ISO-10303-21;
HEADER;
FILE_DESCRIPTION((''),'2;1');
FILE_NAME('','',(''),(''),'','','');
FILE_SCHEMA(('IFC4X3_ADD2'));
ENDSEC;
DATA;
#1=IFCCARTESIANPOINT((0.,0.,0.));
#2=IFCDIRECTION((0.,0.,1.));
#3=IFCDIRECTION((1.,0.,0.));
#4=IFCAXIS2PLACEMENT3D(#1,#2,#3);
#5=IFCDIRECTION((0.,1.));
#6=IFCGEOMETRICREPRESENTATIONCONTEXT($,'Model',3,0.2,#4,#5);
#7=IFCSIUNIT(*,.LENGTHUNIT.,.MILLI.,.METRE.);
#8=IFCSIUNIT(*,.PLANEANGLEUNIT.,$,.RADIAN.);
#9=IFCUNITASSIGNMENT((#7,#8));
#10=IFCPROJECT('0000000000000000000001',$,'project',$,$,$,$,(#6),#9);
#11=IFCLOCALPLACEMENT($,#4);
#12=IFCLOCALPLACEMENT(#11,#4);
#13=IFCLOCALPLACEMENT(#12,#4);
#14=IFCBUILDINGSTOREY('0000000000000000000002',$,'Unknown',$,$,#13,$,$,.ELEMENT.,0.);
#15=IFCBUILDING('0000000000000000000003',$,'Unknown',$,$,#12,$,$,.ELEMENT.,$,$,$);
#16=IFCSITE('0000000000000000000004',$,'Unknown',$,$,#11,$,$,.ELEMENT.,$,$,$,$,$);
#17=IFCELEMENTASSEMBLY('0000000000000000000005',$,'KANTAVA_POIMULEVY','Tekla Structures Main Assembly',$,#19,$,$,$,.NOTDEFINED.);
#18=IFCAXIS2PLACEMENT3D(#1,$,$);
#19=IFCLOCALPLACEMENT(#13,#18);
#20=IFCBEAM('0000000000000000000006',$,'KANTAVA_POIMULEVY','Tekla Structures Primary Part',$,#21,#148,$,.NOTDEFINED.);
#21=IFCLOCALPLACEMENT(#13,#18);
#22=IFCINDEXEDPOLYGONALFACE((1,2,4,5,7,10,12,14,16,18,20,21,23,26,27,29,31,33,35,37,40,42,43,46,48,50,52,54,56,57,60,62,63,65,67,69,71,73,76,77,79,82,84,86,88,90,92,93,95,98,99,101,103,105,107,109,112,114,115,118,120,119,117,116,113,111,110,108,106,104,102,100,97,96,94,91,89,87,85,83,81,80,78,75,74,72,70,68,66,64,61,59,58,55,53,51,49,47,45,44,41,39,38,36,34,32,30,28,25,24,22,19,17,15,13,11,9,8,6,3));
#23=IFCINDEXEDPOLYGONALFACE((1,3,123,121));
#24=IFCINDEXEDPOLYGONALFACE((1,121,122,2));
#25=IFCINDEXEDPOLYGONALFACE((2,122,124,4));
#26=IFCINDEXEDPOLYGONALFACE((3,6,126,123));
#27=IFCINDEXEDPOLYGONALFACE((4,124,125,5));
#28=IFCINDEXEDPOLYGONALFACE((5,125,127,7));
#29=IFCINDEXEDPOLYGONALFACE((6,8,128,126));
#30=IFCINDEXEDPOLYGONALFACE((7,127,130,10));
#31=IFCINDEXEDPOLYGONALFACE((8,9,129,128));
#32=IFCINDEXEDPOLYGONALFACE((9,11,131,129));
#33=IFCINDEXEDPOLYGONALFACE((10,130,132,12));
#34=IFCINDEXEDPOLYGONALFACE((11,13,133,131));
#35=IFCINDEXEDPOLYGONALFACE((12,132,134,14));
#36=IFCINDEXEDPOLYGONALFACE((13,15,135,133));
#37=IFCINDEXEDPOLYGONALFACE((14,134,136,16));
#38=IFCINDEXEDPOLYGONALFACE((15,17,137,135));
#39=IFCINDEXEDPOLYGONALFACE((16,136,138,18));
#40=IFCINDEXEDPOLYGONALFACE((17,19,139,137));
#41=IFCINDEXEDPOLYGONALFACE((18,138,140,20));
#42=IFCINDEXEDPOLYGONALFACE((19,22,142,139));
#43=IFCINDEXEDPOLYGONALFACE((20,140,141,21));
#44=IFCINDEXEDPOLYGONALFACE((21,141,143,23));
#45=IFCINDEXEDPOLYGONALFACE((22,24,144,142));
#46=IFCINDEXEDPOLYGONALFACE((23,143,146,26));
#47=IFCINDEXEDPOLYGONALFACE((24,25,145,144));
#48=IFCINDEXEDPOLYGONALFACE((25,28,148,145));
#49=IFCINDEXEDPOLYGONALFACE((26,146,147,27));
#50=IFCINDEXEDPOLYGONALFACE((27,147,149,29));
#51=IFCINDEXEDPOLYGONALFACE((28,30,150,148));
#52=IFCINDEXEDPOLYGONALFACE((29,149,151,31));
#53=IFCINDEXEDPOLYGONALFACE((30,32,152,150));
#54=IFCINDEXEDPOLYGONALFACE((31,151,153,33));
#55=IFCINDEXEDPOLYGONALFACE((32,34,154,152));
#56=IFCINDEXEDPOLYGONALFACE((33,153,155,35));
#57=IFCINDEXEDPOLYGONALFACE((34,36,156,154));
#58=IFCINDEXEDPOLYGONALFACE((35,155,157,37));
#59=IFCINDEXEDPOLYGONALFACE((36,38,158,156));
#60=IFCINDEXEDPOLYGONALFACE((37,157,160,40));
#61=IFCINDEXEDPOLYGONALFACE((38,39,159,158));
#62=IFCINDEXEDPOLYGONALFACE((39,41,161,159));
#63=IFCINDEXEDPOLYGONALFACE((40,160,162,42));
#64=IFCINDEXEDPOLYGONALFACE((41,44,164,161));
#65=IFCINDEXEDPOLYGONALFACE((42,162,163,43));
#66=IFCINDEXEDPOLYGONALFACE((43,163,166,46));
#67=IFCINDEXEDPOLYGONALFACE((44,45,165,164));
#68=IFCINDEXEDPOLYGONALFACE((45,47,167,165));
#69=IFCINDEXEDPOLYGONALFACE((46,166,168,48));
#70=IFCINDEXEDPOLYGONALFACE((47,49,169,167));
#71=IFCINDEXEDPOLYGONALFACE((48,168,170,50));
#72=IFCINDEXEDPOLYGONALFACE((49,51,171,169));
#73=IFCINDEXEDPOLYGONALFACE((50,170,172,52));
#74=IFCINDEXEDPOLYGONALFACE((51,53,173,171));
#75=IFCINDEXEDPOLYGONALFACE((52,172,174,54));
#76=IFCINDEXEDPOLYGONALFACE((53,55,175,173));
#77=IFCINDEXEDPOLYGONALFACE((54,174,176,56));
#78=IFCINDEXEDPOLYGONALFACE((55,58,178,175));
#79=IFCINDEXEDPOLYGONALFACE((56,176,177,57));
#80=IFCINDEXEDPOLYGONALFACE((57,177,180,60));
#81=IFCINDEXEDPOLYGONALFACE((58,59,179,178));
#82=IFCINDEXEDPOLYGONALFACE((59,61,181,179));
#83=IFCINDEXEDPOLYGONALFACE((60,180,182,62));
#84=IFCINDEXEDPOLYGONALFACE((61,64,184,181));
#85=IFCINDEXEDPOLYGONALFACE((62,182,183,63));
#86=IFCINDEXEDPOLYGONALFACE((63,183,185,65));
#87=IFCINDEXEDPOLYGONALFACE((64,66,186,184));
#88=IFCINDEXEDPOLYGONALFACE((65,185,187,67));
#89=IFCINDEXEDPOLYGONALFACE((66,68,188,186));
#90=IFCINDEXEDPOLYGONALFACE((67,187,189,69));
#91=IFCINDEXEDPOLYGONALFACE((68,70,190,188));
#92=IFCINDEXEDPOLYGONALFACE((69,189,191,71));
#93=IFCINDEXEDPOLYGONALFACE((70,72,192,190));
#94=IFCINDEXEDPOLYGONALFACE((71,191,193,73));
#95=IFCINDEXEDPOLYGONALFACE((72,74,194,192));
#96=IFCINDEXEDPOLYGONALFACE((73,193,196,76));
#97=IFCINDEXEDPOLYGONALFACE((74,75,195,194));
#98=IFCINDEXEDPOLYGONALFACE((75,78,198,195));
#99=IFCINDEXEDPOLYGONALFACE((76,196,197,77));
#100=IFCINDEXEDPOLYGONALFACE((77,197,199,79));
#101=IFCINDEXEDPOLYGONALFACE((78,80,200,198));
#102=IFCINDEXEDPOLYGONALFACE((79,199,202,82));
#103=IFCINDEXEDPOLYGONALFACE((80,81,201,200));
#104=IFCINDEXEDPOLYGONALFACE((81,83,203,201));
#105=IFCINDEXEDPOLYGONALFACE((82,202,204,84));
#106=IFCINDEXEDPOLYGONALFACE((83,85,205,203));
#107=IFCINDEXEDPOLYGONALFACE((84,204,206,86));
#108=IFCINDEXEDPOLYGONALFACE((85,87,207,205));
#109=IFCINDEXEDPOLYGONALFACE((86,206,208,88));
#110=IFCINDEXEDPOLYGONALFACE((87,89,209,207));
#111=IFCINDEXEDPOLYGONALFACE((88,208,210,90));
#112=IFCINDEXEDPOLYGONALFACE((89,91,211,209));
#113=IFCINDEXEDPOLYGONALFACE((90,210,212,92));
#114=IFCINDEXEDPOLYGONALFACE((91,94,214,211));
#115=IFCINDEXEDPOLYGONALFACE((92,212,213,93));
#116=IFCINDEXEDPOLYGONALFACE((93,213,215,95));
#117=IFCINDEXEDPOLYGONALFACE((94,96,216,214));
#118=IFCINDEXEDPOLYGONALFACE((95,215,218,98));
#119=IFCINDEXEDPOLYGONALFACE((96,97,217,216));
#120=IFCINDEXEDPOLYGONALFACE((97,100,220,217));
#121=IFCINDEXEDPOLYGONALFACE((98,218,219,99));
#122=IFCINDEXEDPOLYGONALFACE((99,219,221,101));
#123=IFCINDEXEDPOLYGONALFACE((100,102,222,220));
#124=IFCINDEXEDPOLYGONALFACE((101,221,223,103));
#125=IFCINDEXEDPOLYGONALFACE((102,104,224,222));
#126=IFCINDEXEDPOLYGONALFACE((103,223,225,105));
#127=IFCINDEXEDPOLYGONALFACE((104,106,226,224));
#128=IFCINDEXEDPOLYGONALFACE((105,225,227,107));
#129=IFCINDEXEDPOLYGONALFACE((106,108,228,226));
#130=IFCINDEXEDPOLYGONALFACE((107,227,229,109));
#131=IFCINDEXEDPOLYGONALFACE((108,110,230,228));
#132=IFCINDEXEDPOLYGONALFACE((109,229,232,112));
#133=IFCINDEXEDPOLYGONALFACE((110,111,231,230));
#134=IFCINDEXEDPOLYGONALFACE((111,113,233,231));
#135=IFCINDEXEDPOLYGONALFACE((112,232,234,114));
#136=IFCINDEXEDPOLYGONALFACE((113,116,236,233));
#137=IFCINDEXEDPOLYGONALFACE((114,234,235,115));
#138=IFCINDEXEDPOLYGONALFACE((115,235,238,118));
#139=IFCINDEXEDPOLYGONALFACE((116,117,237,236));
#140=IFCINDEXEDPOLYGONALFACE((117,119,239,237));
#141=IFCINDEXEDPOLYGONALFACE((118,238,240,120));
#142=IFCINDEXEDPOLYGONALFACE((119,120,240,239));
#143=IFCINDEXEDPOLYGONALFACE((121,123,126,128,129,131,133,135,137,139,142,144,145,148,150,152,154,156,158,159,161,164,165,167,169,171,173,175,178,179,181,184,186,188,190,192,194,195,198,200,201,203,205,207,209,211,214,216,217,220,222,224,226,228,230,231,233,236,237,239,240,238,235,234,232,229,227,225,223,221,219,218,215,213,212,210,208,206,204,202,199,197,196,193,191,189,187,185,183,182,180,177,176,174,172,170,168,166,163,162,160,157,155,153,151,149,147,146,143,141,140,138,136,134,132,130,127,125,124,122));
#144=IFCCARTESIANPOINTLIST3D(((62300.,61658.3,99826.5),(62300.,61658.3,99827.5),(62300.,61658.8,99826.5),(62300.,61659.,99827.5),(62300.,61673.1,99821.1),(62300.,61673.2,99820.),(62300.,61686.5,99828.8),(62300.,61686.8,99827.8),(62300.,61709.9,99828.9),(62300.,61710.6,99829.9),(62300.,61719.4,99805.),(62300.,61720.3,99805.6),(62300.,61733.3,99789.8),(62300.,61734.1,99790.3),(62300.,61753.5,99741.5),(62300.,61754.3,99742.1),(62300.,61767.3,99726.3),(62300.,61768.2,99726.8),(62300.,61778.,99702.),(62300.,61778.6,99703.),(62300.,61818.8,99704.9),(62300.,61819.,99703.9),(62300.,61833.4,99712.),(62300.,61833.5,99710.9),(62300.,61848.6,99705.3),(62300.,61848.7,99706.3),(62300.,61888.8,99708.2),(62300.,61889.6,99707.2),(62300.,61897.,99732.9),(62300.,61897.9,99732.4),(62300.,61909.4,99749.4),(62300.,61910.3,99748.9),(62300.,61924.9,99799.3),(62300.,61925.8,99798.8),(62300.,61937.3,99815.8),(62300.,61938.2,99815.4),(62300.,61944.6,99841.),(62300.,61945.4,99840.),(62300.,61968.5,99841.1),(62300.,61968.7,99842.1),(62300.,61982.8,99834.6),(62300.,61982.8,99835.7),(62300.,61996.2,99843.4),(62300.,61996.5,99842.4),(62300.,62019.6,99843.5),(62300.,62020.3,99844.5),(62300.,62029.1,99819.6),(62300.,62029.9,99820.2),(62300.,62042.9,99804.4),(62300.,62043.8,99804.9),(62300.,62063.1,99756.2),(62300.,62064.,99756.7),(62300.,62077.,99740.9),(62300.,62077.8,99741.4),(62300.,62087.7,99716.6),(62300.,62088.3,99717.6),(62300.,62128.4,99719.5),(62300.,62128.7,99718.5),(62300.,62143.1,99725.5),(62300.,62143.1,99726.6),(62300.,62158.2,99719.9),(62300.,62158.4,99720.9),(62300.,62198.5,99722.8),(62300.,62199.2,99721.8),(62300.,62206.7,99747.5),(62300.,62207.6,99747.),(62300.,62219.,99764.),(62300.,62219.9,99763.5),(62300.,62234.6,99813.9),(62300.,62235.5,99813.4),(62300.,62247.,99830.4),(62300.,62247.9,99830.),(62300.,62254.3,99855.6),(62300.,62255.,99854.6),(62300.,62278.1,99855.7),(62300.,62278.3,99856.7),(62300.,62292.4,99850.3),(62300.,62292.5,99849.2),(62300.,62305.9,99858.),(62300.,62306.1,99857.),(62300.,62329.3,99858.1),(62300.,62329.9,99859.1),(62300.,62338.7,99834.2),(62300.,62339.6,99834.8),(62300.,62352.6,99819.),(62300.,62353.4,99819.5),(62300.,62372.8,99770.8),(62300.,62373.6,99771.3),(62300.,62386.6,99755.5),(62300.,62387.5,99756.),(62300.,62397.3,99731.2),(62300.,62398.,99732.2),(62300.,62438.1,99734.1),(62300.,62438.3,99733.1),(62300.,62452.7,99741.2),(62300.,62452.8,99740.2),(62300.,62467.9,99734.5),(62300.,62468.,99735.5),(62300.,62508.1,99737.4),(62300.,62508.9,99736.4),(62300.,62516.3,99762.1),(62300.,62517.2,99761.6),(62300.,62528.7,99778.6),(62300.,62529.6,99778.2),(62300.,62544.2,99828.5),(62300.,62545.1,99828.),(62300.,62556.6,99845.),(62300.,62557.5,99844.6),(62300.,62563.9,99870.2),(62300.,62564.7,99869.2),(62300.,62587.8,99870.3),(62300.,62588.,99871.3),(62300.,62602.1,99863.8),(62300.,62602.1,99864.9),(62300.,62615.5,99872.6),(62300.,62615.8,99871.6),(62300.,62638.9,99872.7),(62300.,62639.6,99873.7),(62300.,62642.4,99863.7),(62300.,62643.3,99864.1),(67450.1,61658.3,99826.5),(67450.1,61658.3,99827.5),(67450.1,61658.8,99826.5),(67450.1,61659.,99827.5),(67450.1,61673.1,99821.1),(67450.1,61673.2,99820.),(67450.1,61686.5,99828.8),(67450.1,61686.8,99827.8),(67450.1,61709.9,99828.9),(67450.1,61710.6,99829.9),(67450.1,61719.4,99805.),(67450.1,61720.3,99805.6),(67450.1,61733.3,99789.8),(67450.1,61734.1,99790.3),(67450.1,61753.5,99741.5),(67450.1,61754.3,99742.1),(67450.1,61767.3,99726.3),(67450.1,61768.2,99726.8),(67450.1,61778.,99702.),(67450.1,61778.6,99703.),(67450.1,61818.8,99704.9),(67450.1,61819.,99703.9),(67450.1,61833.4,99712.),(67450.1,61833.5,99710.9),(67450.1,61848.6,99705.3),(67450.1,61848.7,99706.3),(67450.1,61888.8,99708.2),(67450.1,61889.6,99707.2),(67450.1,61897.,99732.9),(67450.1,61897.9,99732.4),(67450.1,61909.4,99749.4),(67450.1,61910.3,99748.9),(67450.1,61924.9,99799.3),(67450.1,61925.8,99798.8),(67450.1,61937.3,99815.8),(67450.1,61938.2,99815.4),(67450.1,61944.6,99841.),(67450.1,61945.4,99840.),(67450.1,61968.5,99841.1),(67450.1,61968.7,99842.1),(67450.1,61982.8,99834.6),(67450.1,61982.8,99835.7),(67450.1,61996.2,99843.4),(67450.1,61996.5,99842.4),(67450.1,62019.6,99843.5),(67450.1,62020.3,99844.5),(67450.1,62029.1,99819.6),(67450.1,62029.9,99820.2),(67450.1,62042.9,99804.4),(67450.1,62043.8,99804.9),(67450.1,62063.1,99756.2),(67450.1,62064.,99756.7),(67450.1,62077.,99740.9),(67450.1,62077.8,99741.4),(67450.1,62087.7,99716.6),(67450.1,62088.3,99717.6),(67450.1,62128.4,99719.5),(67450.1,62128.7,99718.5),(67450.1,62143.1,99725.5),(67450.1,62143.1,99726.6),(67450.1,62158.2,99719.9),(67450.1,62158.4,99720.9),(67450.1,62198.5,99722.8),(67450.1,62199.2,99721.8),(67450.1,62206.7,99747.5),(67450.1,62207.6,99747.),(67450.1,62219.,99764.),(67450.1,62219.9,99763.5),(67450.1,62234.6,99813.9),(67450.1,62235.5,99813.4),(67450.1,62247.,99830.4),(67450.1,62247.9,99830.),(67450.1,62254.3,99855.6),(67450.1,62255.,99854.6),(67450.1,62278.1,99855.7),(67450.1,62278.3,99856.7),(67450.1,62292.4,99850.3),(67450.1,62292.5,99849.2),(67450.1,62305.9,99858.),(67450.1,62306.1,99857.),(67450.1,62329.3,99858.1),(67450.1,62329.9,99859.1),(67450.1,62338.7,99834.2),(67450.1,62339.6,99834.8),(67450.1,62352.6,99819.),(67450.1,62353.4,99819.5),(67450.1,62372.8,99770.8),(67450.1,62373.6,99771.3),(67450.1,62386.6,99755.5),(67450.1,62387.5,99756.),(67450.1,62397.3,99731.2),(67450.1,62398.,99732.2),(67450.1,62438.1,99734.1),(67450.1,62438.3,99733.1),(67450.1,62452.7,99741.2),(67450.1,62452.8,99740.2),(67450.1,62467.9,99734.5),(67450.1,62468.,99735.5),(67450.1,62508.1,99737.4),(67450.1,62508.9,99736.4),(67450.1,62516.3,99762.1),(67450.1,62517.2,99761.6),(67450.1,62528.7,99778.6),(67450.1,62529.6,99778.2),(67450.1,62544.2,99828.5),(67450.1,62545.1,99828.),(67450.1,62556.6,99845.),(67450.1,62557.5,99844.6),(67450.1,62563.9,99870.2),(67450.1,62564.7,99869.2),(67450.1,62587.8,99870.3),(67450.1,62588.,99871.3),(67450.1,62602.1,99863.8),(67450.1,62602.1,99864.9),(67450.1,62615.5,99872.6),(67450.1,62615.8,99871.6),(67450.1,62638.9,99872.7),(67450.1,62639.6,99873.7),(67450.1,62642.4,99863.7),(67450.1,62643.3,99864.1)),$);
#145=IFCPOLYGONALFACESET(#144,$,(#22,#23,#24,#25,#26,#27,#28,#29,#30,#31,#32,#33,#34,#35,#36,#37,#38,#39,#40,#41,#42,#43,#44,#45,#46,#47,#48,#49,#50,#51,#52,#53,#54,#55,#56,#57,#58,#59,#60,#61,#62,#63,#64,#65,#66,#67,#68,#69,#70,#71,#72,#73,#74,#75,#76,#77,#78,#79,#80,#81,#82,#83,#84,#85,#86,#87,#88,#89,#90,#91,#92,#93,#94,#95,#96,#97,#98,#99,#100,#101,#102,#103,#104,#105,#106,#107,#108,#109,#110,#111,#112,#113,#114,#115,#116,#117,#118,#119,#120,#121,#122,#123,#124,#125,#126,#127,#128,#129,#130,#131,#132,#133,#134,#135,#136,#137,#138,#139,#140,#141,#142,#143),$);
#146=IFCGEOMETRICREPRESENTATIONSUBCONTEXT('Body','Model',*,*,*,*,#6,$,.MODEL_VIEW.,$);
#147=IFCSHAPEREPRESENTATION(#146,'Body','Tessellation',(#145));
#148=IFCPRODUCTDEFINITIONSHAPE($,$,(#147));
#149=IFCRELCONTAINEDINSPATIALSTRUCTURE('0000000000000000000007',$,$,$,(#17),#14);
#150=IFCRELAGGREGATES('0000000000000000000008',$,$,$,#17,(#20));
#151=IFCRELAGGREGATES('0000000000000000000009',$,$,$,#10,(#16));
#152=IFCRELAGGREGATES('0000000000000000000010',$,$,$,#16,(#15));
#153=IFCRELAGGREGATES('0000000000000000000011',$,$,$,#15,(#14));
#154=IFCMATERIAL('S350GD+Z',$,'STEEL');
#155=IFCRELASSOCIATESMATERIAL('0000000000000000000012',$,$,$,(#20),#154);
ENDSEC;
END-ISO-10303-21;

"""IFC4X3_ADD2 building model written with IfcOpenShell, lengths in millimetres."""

from ifc_helpers import new_model, si_unit, direction, frame, origin_with_axes, place, context, subcontext, project, spatial, line, indexed_curve, outline, extrude, material, element, aggregate, save


model = new_model("IFC4X3_ADD2")

# Units and contexts
model_context = context("Model", 3, precision=0.2, world=origin_with_axes(), true_north=direction((0.0, 1.0)))
body_context = subcontext(model_context, "Body", "Model", "MODEL_VIEW")
ifc_project = project(units=[si_unit("LENGTHUNIT", "METRE", prefix="MILLI"), si_unit("PLANEANGLEUNIT", "RADIAN")], contexts=[model_context])

# Site, building, storey
site_placement = place(None, origin_with_axes())
site = spatial("IfcSite", under=ifc_project, at=site_placement, Name="Unknown", CompositionType="ELEMENT")
building_placement = place(site_placement, origin_with_axes())
building = spatial("IfcBuilding", under=site, at=building_placement, Name="Unknown", CompositionType="ELEMENT")
storey_placement = place(building_placement, origin_with_axes())
storey = spatial("IfcBuildingStorey", under=building, at=storey_placement, Name="Unknown", CompositionType="ELEMENT", Elevation=0.0)

# Element assembly, beam
assembly_1_placement = place(storey_placement, frame((62300.0, 62140.4, 99784.6), z_axis=(0.0, -0.99889, -0.047106), x_axis=(1.0, 0.0, 0.0)))
assembly_1 = element("IfcElementAssembly", 1, at=assembly_1_placement, inside=storey, Name="KANTAVA_POIMULEVY", Description="Tekla Structures Main Assembly", PredefinedType="NOTDEFINED")
ifc_material_1 = material(Name="S350GD+Z", Category="STEEL")
beam_1_placement = place(assembly_1_placement, origin_with_axes())
beam_1 = element("IfcBeam", 2, at=beam_1_placement, material=ifc_material_1, Name="KANTAVA_POIMULEVY", Description="Tekla Structures Primary Part", PredefinedType="NOTDEFINED", context=body_context, shape_type="SolidModel", body=[
    extrude(outline(indexed_curve([(479.5, 65.5), (478.8, 65.5), (465.0, 58.5), (451.2, 65.5), (427.1, 65.5), (418.6, 40.7), (405.5, 24.8), (387.6, -24.3), (374.5, -40.2), (365.1, -64.5), (325.0, -64.5), (310.0, -58.1), (295.0, -64.5), (254.8, -64.5), (245.5, -40.2), (232.4, -24.3), (214.5, 24.8), (201.4, 40.7), (192.9, 65.5), (168.8, 65.5), (155.0, 58.5), (141.2, 65.5), (117.1, 65.5), (108.6, 40.7), (95.5, 24.8), (77.6, -24.3), (64.5, -40.2), (55.1, -64.5), (15.0, -64.5), (0.0, -58.1), (-15.0, -64.5), (-55.2, -64.5), (-64.5, -40.2), (-77.6, -24.3), (-95.5, 24.8), (-108.6, 40.7), (-117.2, 65.5), (-141.2, 65.5), (-155.0, 58.5), (-168.8, 65.5), (-192.9, 65.5), (-201.4, 40.7), (-214.5, 24.8), (-232.4, -24.3), (-245.5, -40.2), (-254.9, -64.5), (-295.0, -64.5), (-310.0, -58.1), (-325.0, -64.5), (-365.2, -64.5), (-374.5, -40.2), (-387.6, -24.3), (-405.5, 24.8), (-418.6, 40.7), (-427.1, 65.5), (-451.2, 65.5), (-465.0, 58.5), (-478.8, 65.5), (-502.9, 65.5), (-506.2, 55.7), (-505.2, 55.4), (-502.1, 64.5), (-479.0, 64.5), (-465.0, 57.3), (-451.0, 64.5), (-427.9, 64.5), (-419.5, 40.2), (-406.4, 24.3), (-388.5, -24.8), (-375.4, -40.7), (-365.9, -65.5), (-324.8, -65.5), (-310.0, -59.1), (-295.2, -65.5), (-254.2, -65.5), (-244.6, -40.7), (-231.5, -24.8), (-213.6, 24.3), (-200.5, 40.2), (-192.1, 64.5), (-169.0, 64.5), (-155.0, 57.3), (-141.0, 64.5), (-117.9, 64.5), (-109.5, 40.2), (-96.4, 24.3), (-78.5, -24.8), (-65.4, -40.7), (-55.9, -65.5), (-14.8, -65.5), (0.0, -59.1), (14.8, -65.5), (55.8, -65.5), (65.4, -40.7), (78.5, -24.8), (96.4, 24.3), (109.5, 40.2), (117.8, 64.5), (141.0, 64.5), (155.0, 57.3), (169.0, 64.5), (192.1, 64.5), (200.5, 40.2), (213.6, 24.3), (231.5, -24.8), (244.6, -40.7), (254.1, -65.5), (295.2, -65.5), (310.0, -59.1), (324.8, -65.5), (365.8, -65.5), (375.4, -40.7), (388.5, -24.8), (406.4, 24.3), (419.5, 40.2), (427.9, 64.5), (451.0, 64.5), (465.0, 57.3), (479.0, 64.5), (479.5, 64.5)], segments=[line(1, 2, 3, 4, 5, 6, 7, 8, 9, 10, 11, 12, 13, 14, 15, 16, 17, 18, 19, 20, 21, 22, 23, 24, 25, 26, 27, 28, 29, 30, 31, 32, 33, 34, 35, 36, 37, 38, 39, 40, 41, 42, 43, 44, 45, 46, 47, 48, 49, 50, 51, 52, 53, 54, 55, 56, 57, 58, 59, 60, 61, 62, 63, 64, 65, 66, 67, 68, 69, 70, 71, 72, 73, 74, 75, 76, 77, 78, 79, 80, 81, 82, 83, 84, 85, 86, 87, 88, 89, 90, 91, 92, 93, 94, 95, 96, 97, 98, 99, 100, 101, 102, 103, 104, 105, 106, 107, 108, 109, 110, 111, 112, 113, 114, 115, 116, 117, 118, 119, 120, 1)])), frame((0.0, 0.0, 0.0), z_axis=(-1.0, 0.0, 0.0), x_axis=(0.0, 0.0, 1.0)), (0.0, 0.0, -1.0), 5150.1),
])
aggregate(assembly_1, [beam_1])

save(model, "model.ifc")
